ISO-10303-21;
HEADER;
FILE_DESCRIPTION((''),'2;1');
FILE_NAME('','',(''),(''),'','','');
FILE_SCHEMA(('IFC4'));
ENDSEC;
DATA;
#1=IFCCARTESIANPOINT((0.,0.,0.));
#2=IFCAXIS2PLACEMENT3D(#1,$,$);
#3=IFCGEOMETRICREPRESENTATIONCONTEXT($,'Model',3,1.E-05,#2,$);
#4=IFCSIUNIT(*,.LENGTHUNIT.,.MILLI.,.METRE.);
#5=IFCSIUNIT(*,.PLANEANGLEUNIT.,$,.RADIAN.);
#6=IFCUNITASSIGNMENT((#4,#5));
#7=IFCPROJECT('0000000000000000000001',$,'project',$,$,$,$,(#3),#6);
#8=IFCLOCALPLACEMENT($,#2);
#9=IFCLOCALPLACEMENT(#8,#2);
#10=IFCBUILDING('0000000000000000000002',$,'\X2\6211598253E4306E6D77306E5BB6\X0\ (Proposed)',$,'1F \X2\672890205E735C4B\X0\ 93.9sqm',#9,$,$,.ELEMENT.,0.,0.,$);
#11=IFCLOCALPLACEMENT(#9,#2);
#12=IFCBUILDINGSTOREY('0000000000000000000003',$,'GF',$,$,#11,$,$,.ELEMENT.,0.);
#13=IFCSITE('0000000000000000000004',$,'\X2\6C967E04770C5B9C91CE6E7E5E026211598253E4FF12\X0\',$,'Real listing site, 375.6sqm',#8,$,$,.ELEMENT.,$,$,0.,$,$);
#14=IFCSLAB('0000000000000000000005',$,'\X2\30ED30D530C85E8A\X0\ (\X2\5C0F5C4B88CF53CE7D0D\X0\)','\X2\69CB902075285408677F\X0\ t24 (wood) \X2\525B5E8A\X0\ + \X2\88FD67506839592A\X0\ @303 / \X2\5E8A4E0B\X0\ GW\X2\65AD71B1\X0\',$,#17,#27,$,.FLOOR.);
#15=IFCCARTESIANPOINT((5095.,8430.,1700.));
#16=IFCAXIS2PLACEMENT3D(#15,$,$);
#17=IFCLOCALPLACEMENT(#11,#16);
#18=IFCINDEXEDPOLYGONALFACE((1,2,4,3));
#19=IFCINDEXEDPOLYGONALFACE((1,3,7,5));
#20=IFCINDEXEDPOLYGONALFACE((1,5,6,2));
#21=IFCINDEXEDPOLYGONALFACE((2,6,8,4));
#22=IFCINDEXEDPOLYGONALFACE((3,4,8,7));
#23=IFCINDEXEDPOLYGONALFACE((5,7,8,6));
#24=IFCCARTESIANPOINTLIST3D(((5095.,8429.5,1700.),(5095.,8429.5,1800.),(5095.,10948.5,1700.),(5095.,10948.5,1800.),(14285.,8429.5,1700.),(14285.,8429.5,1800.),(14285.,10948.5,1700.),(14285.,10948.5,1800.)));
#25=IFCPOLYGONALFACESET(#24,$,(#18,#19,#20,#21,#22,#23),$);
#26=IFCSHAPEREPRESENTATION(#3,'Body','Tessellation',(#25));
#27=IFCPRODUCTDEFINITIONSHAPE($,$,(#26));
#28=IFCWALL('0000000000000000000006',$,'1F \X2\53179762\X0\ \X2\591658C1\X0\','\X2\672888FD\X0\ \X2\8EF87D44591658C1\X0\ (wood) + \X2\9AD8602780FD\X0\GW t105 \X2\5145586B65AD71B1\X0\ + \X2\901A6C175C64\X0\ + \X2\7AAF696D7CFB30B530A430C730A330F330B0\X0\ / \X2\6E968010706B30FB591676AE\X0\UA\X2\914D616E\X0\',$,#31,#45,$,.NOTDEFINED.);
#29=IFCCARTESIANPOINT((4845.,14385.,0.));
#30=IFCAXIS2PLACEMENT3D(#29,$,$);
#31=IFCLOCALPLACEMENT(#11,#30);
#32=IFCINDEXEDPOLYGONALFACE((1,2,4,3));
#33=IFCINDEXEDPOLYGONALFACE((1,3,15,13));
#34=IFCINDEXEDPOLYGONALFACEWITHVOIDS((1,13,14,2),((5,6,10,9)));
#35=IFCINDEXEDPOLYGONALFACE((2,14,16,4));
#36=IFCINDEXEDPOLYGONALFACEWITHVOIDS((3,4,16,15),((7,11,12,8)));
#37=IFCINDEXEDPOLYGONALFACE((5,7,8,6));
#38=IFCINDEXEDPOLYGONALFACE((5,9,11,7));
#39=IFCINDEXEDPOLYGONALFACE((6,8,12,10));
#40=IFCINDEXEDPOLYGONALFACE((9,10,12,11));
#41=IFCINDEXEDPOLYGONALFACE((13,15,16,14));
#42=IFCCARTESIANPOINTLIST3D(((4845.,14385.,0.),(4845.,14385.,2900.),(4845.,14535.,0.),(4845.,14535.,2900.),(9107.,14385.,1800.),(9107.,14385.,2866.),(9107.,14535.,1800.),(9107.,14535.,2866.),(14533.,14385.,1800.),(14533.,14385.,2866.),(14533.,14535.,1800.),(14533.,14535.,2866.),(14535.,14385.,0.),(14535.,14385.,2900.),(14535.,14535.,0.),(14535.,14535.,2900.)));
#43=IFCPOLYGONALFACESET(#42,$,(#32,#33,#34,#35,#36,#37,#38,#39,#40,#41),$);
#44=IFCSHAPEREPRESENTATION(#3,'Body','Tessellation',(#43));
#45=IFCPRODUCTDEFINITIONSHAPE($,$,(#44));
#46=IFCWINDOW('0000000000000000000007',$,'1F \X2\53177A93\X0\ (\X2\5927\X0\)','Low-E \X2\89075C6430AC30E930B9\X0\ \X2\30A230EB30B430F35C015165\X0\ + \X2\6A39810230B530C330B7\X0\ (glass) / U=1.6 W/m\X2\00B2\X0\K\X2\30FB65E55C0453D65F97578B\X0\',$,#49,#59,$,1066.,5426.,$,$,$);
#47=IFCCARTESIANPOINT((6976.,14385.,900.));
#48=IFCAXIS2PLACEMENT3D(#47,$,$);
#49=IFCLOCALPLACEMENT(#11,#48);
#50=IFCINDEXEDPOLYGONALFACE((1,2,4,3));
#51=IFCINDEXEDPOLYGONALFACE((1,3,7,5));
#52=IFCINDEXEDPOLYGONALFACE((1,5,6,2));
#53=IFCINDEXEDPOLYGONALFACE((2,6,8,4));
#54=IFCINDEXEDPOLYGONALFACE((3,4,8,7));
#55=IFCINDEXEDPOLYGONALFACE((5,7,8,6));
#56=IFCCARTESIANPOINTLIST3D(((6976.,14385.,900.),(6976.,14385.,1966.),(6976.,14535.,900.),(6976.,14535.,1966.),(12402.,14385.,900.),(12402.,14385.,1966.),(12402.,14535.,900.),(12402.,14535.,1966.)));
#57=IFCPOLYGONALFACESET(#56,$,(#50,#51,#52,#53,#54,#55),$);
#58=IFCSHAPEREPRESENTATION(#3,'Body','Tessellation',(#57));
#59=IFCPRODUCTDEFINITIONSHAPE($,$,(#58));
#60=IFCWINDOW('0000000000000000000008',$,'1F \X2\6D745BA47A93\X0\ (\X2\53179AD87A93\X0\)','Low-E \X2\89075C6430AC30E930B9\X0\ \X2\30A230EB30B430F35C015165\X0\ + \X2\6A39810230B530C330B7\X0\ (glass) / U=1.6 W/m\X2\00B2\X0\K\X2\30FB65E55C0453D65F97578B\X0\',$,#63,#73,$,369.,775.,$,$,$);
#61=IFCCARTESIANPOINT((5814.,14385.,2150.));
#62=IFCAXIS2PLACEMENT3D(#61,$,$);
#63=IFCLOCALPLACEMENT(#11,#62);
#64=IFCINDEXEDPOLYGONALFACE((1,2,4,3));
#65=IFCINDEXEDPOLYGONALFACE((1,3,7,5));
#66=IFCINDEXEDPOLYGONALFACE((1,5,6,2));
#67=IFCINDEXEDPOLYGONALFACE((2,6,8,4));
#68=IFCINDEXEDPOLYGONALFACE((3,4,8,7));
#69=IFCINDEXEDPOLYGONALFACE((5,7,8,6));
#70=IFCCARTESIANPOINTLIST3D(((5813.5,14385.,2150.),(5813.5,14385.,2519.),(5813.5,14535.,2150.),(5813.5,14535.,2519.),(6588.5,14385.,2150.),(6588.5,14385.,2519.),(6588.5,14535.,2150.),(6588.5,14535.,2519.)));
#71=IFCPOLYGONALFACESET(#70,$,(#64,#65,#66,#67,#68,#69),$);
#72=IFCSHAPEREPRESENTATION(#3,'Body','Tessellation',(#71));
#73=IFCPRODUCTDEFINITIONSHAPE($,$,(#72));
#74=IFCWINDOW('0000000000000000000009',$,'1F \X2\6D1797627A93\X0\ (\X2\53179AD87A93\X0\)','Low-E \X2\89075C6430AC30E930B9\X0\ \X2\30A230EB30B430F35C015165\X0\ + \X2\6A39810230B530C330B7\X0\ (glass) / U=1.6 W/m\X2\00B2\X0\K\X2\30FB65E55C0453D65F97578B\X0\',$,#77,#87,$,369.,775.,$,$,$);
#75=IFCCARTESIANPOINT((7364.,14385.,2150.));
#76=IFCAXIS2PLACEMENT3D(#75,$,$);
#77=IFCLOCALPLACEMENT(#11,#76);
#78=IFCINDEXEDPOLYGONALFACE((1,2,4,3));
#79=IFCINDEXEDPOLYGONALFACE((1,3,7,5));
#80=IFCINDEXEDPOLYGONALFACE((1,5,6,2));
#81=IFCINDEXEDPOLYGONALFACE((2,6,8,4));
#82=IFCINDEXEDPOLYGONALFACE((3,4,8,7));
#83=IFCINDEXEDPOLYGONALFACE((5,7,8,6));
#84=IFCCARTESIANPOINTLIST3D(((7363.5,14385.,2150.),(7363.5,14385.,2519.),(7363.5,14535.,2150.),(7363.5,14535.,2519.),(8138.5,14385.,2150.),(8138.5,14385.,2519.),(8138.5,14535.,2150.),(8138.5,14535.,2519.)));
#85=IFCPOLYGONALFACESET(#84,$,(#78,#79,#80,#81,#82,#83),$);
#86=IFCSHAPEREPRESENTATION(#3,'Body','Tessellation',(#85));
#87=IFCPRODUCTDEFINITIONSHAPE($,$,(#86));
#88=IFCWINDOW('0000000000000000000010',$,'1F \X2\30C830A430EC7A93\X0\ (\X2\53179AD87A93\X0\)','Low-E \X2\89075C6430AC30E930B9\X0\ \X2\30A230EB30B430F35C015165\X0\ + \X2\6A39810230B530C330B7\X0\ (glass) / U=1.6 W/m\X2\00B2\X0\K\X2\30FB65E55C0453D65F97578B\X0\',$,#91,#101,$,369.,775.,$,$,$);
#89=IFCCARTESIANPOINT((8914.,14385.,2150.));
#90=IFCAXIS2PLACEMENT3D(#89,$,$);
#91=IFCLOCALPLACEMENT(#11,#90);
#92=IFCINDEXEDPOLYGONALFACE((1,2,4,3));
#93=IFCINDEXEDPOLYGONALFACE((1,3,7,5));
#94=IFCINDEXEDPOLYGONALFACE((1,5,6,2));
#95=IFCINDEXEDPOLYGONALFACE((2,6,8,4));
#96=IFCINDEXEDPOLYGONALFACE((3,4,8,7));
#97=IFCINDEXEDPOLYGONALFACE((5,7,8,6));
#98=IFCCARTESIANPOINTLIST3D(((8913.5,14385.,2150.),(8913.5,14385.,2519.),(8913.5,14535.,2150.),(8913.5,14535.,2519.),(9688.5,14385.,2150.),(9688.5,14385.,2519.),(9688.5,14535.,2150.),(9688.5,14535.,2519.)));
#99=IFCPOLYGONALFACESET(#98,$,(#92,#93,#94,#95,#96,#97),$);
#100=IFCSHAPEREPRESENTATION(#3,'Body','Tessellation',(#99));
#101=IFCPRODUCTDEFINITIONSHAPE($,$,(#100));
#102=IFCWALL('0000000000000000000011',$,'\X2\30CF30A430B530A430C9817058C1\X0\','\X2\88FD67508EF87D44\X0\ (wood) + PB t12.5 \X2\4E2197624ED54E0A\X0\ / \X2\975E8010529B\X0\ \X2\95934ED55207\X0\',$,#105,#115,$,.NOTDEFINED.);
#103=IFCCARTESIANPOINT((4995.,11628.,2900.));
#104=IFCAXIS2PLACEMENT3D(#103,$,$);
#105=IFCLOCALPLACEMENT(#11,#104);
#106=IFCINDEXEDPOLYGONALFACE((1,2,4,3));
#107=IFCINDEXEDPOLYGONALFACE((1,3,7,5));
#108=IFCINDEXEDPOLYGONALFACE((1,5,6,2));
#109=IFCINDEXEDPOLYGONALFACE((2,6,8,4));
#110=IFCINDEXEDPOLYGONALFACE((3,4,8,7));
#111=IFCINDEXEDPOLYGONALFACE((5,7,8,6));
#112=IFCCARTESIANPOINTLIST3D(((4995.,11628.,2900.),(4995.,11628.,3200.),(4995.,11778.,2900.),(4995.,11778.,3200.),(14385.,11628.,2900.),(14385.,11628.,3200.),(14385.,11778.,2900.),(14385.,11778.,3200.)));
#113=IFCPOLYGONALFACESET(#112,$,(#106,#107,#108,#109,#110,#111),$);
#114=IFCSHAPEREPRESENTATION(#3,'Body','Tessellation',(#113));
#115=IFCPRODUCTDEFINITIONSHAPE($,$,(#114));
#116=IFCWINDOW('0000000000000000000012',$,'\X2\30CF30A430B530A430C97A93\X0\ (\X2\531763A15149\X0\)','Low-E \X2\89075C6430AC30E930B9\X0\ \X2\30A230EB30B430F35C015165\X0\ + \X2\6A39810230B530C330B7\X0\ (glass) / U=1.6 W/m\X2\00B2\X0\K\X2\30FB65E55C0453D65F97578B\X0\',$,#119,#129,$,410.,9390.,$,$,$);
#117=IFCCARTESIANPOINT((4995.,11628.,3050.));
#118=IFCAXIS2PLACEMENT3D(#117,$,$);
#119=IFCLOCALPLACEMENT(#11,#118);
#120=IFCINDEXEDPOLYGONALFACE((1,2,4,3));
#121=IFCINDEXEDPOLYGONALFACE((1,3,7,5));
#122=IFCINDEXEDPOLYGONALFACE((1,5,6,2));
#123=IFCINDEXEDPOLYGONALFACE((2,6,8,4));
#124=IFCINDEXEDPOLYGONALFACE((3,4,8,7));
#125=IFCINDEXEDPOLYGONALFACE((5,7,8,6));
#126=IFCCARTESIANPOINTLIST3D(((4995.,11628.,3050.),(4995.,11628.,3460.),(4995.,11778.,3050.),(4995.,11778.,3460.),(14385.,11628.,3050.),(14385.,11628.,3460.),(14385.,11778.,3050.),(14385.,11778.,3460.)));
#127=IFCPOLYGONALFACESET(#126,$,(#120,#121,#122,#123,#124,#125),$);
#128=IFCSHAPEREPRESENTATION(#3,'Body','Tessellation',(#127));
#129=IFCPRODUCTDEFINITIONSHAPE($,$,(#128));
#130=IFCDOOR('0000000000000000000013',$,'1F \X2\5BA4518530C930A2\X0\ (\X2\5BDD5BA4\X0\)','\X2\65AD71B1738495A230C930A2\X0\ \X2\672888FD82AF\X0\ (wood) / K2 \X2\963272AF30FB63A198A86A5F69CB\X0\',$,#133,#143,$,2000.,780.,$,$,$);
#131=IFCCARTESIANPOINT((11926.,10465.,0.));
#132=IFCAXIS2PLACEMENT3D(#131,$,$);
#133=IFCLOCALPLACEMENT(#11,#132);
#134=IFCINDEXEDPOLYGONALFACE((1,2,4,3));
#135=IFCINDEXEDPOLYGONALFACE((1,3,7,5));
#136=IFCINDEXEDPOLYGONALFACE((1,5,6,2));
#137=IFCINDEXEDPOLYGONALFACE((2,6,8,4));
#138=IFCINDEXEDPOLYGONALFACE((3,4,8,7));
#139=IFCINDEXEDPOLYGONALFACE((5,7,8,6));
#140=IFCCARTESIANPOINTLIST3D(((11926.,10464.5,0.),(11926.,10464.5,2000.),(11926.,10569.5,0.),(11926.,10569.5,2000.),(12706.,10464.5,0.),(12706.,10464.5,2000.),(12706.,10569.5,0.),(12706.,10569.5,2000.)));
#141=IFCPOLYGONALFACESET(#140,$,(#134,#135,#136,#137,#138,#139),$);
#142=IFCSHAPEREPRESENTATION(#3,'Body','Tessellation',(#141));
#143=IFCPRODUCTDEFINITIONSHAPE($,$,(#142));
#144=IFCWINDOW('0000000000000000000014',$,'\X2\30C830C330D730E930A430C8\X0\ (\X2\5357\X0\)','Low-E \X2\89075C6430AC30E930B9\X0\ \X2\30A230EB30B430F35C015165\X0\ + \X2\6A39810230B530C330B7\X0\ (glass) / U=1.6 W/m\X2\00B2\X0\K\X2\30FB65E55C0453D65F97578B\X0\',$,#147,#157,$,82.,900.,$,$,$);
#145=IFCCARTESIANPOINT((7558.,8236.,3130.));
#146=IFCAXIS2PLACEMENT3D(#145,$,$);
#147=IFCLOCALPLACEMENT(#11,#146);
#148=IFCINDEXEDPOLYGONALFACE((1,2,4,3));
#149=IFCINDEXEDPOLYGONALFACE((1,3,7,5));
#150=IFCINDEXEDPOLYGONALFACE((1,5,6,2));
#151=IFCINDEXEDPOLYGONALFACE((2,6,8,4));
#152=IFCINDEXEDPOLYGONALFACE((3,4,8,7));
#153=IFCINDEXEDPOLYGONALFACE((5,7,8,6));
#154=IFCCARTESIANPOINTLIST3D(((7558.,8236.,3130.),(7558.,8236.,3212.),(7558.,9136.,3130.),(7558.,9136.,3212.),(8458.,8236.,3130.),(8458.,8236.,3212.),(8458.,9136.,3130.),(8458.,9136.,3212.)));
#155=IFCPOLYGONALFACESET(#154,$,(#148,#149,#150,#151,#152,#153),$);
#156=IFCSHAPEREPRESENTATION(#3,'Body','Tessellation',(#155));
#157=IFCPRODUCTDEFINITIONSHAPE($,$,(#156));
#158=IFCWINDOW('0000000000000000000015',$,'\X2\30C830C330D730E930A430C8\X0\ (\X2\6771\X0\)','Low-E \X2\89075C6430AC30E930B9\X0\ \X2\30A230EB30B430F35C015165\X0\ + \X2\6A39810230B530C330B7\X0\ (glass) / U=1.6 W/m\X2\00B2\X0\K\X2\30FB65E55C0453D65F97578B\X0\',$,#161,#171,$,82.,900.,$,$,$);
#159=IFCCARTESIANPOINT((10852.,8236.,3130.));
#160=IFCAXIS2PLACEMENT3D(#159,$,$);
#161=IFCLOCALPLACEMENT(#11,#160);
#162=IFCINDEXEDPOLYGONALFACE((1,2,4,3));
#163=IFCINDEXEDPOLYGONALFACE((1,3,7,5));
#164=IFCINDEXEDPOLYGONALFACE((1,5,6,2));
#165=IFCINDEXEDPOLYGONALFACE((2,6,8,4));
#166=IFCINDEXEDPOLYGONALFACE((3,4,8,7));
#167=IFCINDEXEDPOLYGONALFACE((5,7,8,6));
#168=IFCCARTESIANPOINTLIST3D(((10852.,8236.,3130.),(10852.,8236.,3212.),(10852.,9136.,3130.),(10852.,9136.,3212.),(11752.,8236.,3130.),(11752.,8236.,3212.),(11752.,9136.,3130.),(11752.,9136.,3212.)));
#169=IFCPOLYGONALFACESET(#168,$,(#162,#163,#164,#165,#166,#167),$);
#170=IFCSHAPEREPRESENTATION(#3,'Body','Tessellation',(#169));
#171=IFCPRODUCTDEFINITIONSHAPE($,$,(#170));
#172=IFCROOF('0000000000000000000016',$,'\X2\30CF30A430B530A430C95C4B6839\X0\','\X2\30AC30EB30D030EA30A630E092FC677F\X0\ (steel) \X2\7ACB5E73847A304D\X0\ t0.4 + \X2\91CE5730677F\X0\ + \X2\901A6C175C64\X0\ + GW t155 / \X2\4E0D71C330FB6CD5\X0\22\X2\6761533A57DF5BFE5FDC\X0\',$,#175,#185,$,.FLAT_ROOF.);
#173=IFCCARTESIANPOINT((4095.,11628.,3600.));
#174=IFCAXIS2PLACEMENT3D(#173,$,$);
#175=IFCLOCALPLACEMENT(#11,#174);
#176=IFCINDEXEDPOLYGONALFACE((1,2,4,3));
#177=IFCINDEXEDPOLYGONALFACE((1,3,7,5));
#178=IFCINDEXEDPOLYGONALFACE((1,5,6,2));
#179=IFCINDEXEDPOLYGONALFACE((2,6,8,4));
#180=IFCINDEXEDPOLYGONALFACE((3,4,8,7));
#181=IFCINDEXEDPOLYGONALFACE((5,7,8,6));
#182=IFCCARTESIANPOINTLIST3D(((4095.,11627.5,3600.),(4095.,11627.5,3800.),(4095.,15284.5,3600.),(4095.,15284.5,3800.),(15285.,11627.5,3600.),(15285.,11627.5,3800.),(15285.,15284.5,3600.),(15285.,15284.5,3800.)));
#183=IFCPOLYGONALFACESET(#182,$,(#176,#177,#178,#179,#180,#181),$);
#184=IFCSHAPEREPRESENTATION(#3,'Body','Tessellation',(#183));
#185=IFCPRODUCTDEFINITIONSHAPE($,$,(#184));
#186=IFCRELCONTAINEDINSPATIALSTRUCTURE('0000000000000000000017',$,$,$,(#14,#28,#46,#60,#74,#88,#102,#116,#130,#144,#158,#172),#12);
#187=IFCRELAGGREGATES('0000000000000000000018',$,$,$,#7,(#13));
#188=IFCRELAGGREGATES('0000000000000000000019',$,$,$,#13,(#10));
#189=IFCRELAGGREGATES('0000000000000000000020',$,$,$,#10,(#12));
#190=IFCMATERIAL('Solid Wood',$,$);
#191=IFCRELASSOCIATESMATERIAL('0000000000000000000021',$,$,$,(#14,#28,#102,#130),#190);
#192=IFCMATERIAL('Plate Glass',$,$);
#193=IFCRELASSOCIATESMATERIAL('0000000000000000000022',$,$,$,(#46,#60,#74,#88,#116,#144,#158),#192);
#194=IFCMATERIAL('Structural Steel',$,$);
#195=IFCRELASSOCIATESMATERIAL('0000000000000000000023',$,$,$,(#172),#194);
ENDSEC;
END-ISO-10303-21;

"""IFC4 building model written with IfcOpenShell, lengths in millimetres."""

from ifc_helpers import new_model, si_unit, frame, frame_2d, origin, place, context, project, spatial, rectangle, extrude, material, element, fill, save


model = new_model("IFC4")

# Units and contexts
model_context = context("Model", 3, precision=1e-05, world=origin())
ifc_project = project(units=[si_unit("LENGTHUNIT", "METRE", prefix="MILLI"), si_unit("PLANEANGLEUNIT", "RADIAN")], contexts=[model_context])

# Site, building, storey
site_placement = place(None, origin())
site = spatial("IfcSite", under=ifc_project, at=site_placement, Name="沖縄県宜野湾市我如古２", ObjectType="Real listing site, 375.6sqm", CompositionType="ELEMENT", RefElevation=0.0)
building_placement = place(site_placement, origin())
building = spatial("IfcBuilding", under=site, at=building_placement, Name="我如古の海の家 (Proposed)", ObjectType="1F 木造平屋 93.9sqm", CompositionType="ELEMENT", ElevationOfRefHeight=0.0, ElevationOfTerrain=0.0)
storey_placement = place(building_placement, origin())
storey = spatial("IfcBuildingStorey", under=building, at=storey_placement, Name="GF", CompositionType="ELEMENT", Elevation=0.0)

# Slab
ifc_material_1 = material(Name="Solid Wood")
slab_placement = place(storey_placement, frame((5095.0, 8430.0, 1700.0)))
element("IfcSlab", 1, at=slab_placement, inside=storey, material=ifc_material_1, Name="ロフト床 (小屋裏収納)", Description="構造用合板 t24 (wood) 剛床 + 製材根太 @303 / 床下 GW断熱", PredefinedType="FLOOR", context=model_context, shape_type="SweptSolid", body=[
    extrude(rectangle(XDim=9190.0, YDim=2519.0, at=frame_2d((4595.0, 1259.0))), frame((5095.0, 8430.0, 1700.0)), (0.0, 0.0, 1.0), 100.0),
])

# Wall, openings, windows
wall_1_placement = place(storey_placement, frame((4845.0, 14385.0, 0.0)))
wall_1 = element("IfcWall", 2, at=wall_1_placement, inside=storey, material=ifc_material_1, Name="1F 北面 外壁", Description="木製 軸組外壁 (wood) + 高性能GW t105 充填断熱 + 通気層 + 窯業系サイディング / 準耐火・外皮UA配慮", PredefinedType="NOTDEFINED", context=model_context, shape_type="SweptSolid", body=[
    extrude(rectangle(XDim=9690.0, YDim=150.0, at=frame_2d((4845.0, 75.0))), frame((4845.0, 14385.0, 0.0)), (0.0, 0.0, 1.0), 2900.0),
])
opening_1_placement = place(storey_placement, frame((6976.0, 14385.0, 900.0)))
opening_1 = element("IfcOpeningElement", 3, at=opening_1_placement, cuts=wall_1, PredefinedType="NOTDEFINED", context=model_context, shape_type="SweptSolid", body=[
    extrude(rectangle(XDim=5426.0, YDim=150.0, at=frame_2d((2713.0, 75.0))), frame((6976.0, 14385.0, 900.0)), (0.0, 0.0, 1.0), 1066.0),
])
opening_2_placement = place(storey_placement, frame((5814.0, 14385.0, 2150.0)))
opening_2 = element("IfcOpeningElement", 4, at=opening_2_placement, cuts=wall_1, PredefinedType="NOTDEFINED", context=model_context, shape_type="SweptSolid", body=[
    extrude(rectangle(XDim=775.0, YDim=150.0, at=frame_2d((387.0, 75.0))), frame((5814.0, 14385.0, 2150.0)), (0.0, 0.0, 1.0), 369.0),
])
opening_3_placement = place(storey_placement, frame((7364.0, 14385.0, 2150.0)))
opening_3 = element("IfcOpeningElement", 5, at=opening_3_placement, cuts=wall_1, PredefinedType="NOTDEFINED", context=model_context, shape_type="SweptSolid", body=[
    extrude(rectangle(XDim=775.0, YDim=150.0, at=frame_2d((387.0, 75.0))), frame((7364.0, 14385.0, 2150.0)), (0.0, 0.0, 1.0), 369.0),
])
opening_4_placement = place(storey_placement, frame((8914.0, 14385.0, 2150.0)))
opening_4 = element("IfcOpeningElement", 6, at=opening_4_placement, cuts=wall_1, PredefinedType="NOTDEFINED", context=model_context, shape_type="SweptSolid", body=[
    extrude(rectangle(XDim=775.0, YDim=150.0, at=frame_2d((387.0, 75.0))), frame((8914.0, 14385.0, 2150.0)), (0.0, 0.0, 1.0), 369.0),
])
ifc_material_2 = material(Name="Plate Glass")
window_1_placement = place(storey_placement, frame((6976.0, 14385.0, 900.0)))
window_1 = element("IfcWindow", 7, at=window_1_placement, inside=storey, material=ifc_material_2, Name="1F 北窓 (大)", Description="Low-E 複層ガラス アルゴン封入 + 樹脂サッシ (glass) / U=1.6 W/m²K・日射取得型", OverallHeight=1066.0, OverallWidth=5426.0, context=model_context, shape_type="SweptSolid", body=[
    extrude(rectangle(XDim=5426.0, YDim=150.0, at=frame_2d((2713.0, 75.0))), frame((6976.0, 14385.0, 900.0)), (0.0, 0.0, 1.0), 1066.0),
])
fill(opening_1, window_1)
window_2_placement = place(storey_placement, frame((5814.0, 14385.0, 2150.0)))
window_2 = element("IfcWindow", 8, at=window_2_placement, inside=storey, material=ifc_material_2, Name="1F 浴室窓 (北高窓)", Description="Low-E 複層ガラス アルゴン封入 + 樹脂サッシ (glass) / U=1.6 W/m²K・日射取得型", OverallHeight=369.0, OverallWidth=775.0, context=model_context, shape_type="SweptSolid", body=[
    extrude(rectangle(XDim=775.0, YDim=150.0, at=frame_2d((387.0, 75.0))), frame((5814.0, 14385.0, 2150.0)), (0.0, 0.0, 1.0), 369.0),
])
fill(opening_2, window_2)
window_3_placement = place(storey_placement, frame((7364.0, 14385.0, 2150.0)))
window_3 = element("IfcWindow", 9, at=window_3_placement, inside=storey, material=ifc_material_2, Name="1F 洗面窓 (北高窓)", Description="Low-E 複層ガラス アルゴン封入 + 樹脂サッシ (glass) / U=1.6 W/m²K・日射取得型", OverallHeight=369.0, OverallWidth=775.0, context=model_context, shape_type="SweptSolid", body=[
    extrude(rectangle(XDim=775.0, YDim=150.0, at=frame_2d((387.0, 75.0))), frame((7364.0, 14385.0, 2150.0)), (0.0, 0.0, 1.0), 369.0),
])
fill(opening_3, window_3)
window_4_placement = place(storey_placement, frame((8914.0, 14385.0, 2150.0)))
window_4 = element("IfcWindow", 10, at=window_4_placement, inside=storey, material=ifc_material_2, Name="1F トイレ窓 (北高窓)", Description="Low-E 複層ガラス アルゴン封入 + 樹脂サッシ (glass) / U=1.6 W/m²K・日射取得型", OverallHeight=369.0, OverallWidth=775.0, context=model_context, shape_type="SweptSolid", body=[
    extrude(rectangle(XDim=775.0, YDim=150.0, at=frame_2d((387.0, 75.0))), frame((8914.0, 14385.0, 2150.0)), (0.0, 0.0, 1.0), 369.0),
])
fill(opening_4, window_4)

# Wall, opening, window
wall_2_placement = place(storey_placement, frame((4995.0, 11628.0, 2900.0)))
wall_2 = element("IfcWall", 11, at=wall_2_placement, inside=storey, material=ifc_material_1, Name="ハイサイド腰壁", Description="製材軸組 (wood) + PB t12.5 両面仕上 / 非耐力 間仕切", PredefinedType="NOTDEFINED", context=model_context, shape_type="SweptSolid", body=[
    extrude(rectangle(XDim=9390.0, YDim=150.0, at=frame_2d((4695.0, 75.0))), frame((4995.0, 11628.0, 2900.0)), (0.0, 0.0, 1.0), 700.0),
])
opening_5_placement = place(storey_placement, frame((4995.0, 11628.0, 3050.0)))
opening_5 = element("IfcOpeningElement", 12, at=opening_5_placement, cuts=wall_2, PredefinedType="NOTDEFINED", context=model_context, shape_type="SweptSolid", body=[
    extrude(rectangle(XDim=9390.0, YDim=150.0, at=frame_2d((4695.0, 75.0))), frame((4995.0, 11628.0, 3050.0)), (0.0, 0.0, 1.0), 410.0),
])
window_5_placement = place(storey_placement, frame((4995.0, 11628.0, 3050.0)))
window_5 = element("IfcWindow", 13, at=window_5_placement, inside=storey, material=ifc_material_2, Name="ハイサイド窓 (北採光)", Description="Low-E 複層ガラス アルゴン封入 + 樹脂サッシ (glass) / U=1.6 W/m²K・日射取得型", OverallHeight=410.0, OverallWidth=9390.0, context=model_context, shape_type="SweptSolid", body=[
    extrude(rectangle(XDim=9390.0, YDim=150.0, at=frame_2d((4695.0, 75.0))), frame((4995.0, 11628.0, 3050.0)), (0.0, 0.0, 1.0), 410.0),
])
fill(opening_5, window_5)

# Door
door_1_placement = place(storey_placement, frame((11926.0, 10465.0, 0.0)))
element("IfcDoor", 14, at=door_1_placement, inside=storey, material=ifc_material_1, Name="1F 室内ドア (寝室)", Description="断熱玄関ドア 木製芯 (wood) / K2 防犯・採風機構", OverallHeight=2000.0, OverallWidth=780.0, context=model_context, shape_type="SweptSolid", body=[
    extrude(rectangle(XDim=780.0, YDim=105.0, at=frame_2d((390.0, 52.0))), frame((11926.0, 10465.0, 0.0)), (0.0, 0.0, 1.0), 2000.0),
])

# Windows
window_6_placement = place(storey_placement, frame((7558.0, 8236.0, 3130.0)))
element("IfcWindow", 15, at=window_6_placement, inside=storey, material=ifc_material_2, Name="トップライト (南)", Description="Low-E 複層ガラス アルゴン封入 + 樹脂サッシ (glass) / U=1.6 W/m²K・日射取得型", OverallHeight=82.0, OverallWidth=900.0, context=model_context, shape_type="SweptSolid", body=[
    extrude(rectangle(XDim=900.0, YDim=900.0, at=frame_2d((450.0, 450.0))), frame((7558.0, 8236.0, 3130.0)), (0.0, 0.0, 1.0), 82.0),
])
window_7_placement = place(storey_placement, frame((10852.0, 8236.0, 3130.0)))
element("IfcWindow", 16, at=window_7_placement, inside=storey, material=ifc_material_2, Name="トップライト (東)", Description="Low-E 複層ガラス アルゴン封入 + 樹脂サッシ (glass) / U=1.6 W/m²K・日射取得型", OverallHeight=82.0, OverallWidth=900.0, context=model_context, shape_type="SweptSolid", body=[
    extrude(rectangle(XDim=900.0, YDim=900.0, at=frame_2d((450.0, 450.0))), frame((10852.0, 8236.0, 3130.0)), (0.0, 0.0, 1.0), 82.0),
])

# Roof
ifc_material_3 = material(Name="Structural Steel")
roof_placement = place(storey_placement, frame((4095.0, 11628.0, 3600.0)))
element("IfcRoof", 17, at=roof_placement, inside=storey, material=ifc_material_3, Name="ハイサイド屋根", Description="ガルバリウム鋼板 (steel) 立平葺き t0.4 + 野地板 + 通気層 + GW t155 / 不燃・法22条区域対応", PredefinedType="FLAT_ROOF", context=model_context, shape_type="SweptSolid", body=[
    extrude(rectangle(XDim=11190.0, YDim=3657.0, at=frame_2d((5595.0, 1828.0))), frame((4095.0, 11628.0, 3600.0)), (0.0, 0.0, 1.0), 200.0),
])

save(model, "model.ifc")
